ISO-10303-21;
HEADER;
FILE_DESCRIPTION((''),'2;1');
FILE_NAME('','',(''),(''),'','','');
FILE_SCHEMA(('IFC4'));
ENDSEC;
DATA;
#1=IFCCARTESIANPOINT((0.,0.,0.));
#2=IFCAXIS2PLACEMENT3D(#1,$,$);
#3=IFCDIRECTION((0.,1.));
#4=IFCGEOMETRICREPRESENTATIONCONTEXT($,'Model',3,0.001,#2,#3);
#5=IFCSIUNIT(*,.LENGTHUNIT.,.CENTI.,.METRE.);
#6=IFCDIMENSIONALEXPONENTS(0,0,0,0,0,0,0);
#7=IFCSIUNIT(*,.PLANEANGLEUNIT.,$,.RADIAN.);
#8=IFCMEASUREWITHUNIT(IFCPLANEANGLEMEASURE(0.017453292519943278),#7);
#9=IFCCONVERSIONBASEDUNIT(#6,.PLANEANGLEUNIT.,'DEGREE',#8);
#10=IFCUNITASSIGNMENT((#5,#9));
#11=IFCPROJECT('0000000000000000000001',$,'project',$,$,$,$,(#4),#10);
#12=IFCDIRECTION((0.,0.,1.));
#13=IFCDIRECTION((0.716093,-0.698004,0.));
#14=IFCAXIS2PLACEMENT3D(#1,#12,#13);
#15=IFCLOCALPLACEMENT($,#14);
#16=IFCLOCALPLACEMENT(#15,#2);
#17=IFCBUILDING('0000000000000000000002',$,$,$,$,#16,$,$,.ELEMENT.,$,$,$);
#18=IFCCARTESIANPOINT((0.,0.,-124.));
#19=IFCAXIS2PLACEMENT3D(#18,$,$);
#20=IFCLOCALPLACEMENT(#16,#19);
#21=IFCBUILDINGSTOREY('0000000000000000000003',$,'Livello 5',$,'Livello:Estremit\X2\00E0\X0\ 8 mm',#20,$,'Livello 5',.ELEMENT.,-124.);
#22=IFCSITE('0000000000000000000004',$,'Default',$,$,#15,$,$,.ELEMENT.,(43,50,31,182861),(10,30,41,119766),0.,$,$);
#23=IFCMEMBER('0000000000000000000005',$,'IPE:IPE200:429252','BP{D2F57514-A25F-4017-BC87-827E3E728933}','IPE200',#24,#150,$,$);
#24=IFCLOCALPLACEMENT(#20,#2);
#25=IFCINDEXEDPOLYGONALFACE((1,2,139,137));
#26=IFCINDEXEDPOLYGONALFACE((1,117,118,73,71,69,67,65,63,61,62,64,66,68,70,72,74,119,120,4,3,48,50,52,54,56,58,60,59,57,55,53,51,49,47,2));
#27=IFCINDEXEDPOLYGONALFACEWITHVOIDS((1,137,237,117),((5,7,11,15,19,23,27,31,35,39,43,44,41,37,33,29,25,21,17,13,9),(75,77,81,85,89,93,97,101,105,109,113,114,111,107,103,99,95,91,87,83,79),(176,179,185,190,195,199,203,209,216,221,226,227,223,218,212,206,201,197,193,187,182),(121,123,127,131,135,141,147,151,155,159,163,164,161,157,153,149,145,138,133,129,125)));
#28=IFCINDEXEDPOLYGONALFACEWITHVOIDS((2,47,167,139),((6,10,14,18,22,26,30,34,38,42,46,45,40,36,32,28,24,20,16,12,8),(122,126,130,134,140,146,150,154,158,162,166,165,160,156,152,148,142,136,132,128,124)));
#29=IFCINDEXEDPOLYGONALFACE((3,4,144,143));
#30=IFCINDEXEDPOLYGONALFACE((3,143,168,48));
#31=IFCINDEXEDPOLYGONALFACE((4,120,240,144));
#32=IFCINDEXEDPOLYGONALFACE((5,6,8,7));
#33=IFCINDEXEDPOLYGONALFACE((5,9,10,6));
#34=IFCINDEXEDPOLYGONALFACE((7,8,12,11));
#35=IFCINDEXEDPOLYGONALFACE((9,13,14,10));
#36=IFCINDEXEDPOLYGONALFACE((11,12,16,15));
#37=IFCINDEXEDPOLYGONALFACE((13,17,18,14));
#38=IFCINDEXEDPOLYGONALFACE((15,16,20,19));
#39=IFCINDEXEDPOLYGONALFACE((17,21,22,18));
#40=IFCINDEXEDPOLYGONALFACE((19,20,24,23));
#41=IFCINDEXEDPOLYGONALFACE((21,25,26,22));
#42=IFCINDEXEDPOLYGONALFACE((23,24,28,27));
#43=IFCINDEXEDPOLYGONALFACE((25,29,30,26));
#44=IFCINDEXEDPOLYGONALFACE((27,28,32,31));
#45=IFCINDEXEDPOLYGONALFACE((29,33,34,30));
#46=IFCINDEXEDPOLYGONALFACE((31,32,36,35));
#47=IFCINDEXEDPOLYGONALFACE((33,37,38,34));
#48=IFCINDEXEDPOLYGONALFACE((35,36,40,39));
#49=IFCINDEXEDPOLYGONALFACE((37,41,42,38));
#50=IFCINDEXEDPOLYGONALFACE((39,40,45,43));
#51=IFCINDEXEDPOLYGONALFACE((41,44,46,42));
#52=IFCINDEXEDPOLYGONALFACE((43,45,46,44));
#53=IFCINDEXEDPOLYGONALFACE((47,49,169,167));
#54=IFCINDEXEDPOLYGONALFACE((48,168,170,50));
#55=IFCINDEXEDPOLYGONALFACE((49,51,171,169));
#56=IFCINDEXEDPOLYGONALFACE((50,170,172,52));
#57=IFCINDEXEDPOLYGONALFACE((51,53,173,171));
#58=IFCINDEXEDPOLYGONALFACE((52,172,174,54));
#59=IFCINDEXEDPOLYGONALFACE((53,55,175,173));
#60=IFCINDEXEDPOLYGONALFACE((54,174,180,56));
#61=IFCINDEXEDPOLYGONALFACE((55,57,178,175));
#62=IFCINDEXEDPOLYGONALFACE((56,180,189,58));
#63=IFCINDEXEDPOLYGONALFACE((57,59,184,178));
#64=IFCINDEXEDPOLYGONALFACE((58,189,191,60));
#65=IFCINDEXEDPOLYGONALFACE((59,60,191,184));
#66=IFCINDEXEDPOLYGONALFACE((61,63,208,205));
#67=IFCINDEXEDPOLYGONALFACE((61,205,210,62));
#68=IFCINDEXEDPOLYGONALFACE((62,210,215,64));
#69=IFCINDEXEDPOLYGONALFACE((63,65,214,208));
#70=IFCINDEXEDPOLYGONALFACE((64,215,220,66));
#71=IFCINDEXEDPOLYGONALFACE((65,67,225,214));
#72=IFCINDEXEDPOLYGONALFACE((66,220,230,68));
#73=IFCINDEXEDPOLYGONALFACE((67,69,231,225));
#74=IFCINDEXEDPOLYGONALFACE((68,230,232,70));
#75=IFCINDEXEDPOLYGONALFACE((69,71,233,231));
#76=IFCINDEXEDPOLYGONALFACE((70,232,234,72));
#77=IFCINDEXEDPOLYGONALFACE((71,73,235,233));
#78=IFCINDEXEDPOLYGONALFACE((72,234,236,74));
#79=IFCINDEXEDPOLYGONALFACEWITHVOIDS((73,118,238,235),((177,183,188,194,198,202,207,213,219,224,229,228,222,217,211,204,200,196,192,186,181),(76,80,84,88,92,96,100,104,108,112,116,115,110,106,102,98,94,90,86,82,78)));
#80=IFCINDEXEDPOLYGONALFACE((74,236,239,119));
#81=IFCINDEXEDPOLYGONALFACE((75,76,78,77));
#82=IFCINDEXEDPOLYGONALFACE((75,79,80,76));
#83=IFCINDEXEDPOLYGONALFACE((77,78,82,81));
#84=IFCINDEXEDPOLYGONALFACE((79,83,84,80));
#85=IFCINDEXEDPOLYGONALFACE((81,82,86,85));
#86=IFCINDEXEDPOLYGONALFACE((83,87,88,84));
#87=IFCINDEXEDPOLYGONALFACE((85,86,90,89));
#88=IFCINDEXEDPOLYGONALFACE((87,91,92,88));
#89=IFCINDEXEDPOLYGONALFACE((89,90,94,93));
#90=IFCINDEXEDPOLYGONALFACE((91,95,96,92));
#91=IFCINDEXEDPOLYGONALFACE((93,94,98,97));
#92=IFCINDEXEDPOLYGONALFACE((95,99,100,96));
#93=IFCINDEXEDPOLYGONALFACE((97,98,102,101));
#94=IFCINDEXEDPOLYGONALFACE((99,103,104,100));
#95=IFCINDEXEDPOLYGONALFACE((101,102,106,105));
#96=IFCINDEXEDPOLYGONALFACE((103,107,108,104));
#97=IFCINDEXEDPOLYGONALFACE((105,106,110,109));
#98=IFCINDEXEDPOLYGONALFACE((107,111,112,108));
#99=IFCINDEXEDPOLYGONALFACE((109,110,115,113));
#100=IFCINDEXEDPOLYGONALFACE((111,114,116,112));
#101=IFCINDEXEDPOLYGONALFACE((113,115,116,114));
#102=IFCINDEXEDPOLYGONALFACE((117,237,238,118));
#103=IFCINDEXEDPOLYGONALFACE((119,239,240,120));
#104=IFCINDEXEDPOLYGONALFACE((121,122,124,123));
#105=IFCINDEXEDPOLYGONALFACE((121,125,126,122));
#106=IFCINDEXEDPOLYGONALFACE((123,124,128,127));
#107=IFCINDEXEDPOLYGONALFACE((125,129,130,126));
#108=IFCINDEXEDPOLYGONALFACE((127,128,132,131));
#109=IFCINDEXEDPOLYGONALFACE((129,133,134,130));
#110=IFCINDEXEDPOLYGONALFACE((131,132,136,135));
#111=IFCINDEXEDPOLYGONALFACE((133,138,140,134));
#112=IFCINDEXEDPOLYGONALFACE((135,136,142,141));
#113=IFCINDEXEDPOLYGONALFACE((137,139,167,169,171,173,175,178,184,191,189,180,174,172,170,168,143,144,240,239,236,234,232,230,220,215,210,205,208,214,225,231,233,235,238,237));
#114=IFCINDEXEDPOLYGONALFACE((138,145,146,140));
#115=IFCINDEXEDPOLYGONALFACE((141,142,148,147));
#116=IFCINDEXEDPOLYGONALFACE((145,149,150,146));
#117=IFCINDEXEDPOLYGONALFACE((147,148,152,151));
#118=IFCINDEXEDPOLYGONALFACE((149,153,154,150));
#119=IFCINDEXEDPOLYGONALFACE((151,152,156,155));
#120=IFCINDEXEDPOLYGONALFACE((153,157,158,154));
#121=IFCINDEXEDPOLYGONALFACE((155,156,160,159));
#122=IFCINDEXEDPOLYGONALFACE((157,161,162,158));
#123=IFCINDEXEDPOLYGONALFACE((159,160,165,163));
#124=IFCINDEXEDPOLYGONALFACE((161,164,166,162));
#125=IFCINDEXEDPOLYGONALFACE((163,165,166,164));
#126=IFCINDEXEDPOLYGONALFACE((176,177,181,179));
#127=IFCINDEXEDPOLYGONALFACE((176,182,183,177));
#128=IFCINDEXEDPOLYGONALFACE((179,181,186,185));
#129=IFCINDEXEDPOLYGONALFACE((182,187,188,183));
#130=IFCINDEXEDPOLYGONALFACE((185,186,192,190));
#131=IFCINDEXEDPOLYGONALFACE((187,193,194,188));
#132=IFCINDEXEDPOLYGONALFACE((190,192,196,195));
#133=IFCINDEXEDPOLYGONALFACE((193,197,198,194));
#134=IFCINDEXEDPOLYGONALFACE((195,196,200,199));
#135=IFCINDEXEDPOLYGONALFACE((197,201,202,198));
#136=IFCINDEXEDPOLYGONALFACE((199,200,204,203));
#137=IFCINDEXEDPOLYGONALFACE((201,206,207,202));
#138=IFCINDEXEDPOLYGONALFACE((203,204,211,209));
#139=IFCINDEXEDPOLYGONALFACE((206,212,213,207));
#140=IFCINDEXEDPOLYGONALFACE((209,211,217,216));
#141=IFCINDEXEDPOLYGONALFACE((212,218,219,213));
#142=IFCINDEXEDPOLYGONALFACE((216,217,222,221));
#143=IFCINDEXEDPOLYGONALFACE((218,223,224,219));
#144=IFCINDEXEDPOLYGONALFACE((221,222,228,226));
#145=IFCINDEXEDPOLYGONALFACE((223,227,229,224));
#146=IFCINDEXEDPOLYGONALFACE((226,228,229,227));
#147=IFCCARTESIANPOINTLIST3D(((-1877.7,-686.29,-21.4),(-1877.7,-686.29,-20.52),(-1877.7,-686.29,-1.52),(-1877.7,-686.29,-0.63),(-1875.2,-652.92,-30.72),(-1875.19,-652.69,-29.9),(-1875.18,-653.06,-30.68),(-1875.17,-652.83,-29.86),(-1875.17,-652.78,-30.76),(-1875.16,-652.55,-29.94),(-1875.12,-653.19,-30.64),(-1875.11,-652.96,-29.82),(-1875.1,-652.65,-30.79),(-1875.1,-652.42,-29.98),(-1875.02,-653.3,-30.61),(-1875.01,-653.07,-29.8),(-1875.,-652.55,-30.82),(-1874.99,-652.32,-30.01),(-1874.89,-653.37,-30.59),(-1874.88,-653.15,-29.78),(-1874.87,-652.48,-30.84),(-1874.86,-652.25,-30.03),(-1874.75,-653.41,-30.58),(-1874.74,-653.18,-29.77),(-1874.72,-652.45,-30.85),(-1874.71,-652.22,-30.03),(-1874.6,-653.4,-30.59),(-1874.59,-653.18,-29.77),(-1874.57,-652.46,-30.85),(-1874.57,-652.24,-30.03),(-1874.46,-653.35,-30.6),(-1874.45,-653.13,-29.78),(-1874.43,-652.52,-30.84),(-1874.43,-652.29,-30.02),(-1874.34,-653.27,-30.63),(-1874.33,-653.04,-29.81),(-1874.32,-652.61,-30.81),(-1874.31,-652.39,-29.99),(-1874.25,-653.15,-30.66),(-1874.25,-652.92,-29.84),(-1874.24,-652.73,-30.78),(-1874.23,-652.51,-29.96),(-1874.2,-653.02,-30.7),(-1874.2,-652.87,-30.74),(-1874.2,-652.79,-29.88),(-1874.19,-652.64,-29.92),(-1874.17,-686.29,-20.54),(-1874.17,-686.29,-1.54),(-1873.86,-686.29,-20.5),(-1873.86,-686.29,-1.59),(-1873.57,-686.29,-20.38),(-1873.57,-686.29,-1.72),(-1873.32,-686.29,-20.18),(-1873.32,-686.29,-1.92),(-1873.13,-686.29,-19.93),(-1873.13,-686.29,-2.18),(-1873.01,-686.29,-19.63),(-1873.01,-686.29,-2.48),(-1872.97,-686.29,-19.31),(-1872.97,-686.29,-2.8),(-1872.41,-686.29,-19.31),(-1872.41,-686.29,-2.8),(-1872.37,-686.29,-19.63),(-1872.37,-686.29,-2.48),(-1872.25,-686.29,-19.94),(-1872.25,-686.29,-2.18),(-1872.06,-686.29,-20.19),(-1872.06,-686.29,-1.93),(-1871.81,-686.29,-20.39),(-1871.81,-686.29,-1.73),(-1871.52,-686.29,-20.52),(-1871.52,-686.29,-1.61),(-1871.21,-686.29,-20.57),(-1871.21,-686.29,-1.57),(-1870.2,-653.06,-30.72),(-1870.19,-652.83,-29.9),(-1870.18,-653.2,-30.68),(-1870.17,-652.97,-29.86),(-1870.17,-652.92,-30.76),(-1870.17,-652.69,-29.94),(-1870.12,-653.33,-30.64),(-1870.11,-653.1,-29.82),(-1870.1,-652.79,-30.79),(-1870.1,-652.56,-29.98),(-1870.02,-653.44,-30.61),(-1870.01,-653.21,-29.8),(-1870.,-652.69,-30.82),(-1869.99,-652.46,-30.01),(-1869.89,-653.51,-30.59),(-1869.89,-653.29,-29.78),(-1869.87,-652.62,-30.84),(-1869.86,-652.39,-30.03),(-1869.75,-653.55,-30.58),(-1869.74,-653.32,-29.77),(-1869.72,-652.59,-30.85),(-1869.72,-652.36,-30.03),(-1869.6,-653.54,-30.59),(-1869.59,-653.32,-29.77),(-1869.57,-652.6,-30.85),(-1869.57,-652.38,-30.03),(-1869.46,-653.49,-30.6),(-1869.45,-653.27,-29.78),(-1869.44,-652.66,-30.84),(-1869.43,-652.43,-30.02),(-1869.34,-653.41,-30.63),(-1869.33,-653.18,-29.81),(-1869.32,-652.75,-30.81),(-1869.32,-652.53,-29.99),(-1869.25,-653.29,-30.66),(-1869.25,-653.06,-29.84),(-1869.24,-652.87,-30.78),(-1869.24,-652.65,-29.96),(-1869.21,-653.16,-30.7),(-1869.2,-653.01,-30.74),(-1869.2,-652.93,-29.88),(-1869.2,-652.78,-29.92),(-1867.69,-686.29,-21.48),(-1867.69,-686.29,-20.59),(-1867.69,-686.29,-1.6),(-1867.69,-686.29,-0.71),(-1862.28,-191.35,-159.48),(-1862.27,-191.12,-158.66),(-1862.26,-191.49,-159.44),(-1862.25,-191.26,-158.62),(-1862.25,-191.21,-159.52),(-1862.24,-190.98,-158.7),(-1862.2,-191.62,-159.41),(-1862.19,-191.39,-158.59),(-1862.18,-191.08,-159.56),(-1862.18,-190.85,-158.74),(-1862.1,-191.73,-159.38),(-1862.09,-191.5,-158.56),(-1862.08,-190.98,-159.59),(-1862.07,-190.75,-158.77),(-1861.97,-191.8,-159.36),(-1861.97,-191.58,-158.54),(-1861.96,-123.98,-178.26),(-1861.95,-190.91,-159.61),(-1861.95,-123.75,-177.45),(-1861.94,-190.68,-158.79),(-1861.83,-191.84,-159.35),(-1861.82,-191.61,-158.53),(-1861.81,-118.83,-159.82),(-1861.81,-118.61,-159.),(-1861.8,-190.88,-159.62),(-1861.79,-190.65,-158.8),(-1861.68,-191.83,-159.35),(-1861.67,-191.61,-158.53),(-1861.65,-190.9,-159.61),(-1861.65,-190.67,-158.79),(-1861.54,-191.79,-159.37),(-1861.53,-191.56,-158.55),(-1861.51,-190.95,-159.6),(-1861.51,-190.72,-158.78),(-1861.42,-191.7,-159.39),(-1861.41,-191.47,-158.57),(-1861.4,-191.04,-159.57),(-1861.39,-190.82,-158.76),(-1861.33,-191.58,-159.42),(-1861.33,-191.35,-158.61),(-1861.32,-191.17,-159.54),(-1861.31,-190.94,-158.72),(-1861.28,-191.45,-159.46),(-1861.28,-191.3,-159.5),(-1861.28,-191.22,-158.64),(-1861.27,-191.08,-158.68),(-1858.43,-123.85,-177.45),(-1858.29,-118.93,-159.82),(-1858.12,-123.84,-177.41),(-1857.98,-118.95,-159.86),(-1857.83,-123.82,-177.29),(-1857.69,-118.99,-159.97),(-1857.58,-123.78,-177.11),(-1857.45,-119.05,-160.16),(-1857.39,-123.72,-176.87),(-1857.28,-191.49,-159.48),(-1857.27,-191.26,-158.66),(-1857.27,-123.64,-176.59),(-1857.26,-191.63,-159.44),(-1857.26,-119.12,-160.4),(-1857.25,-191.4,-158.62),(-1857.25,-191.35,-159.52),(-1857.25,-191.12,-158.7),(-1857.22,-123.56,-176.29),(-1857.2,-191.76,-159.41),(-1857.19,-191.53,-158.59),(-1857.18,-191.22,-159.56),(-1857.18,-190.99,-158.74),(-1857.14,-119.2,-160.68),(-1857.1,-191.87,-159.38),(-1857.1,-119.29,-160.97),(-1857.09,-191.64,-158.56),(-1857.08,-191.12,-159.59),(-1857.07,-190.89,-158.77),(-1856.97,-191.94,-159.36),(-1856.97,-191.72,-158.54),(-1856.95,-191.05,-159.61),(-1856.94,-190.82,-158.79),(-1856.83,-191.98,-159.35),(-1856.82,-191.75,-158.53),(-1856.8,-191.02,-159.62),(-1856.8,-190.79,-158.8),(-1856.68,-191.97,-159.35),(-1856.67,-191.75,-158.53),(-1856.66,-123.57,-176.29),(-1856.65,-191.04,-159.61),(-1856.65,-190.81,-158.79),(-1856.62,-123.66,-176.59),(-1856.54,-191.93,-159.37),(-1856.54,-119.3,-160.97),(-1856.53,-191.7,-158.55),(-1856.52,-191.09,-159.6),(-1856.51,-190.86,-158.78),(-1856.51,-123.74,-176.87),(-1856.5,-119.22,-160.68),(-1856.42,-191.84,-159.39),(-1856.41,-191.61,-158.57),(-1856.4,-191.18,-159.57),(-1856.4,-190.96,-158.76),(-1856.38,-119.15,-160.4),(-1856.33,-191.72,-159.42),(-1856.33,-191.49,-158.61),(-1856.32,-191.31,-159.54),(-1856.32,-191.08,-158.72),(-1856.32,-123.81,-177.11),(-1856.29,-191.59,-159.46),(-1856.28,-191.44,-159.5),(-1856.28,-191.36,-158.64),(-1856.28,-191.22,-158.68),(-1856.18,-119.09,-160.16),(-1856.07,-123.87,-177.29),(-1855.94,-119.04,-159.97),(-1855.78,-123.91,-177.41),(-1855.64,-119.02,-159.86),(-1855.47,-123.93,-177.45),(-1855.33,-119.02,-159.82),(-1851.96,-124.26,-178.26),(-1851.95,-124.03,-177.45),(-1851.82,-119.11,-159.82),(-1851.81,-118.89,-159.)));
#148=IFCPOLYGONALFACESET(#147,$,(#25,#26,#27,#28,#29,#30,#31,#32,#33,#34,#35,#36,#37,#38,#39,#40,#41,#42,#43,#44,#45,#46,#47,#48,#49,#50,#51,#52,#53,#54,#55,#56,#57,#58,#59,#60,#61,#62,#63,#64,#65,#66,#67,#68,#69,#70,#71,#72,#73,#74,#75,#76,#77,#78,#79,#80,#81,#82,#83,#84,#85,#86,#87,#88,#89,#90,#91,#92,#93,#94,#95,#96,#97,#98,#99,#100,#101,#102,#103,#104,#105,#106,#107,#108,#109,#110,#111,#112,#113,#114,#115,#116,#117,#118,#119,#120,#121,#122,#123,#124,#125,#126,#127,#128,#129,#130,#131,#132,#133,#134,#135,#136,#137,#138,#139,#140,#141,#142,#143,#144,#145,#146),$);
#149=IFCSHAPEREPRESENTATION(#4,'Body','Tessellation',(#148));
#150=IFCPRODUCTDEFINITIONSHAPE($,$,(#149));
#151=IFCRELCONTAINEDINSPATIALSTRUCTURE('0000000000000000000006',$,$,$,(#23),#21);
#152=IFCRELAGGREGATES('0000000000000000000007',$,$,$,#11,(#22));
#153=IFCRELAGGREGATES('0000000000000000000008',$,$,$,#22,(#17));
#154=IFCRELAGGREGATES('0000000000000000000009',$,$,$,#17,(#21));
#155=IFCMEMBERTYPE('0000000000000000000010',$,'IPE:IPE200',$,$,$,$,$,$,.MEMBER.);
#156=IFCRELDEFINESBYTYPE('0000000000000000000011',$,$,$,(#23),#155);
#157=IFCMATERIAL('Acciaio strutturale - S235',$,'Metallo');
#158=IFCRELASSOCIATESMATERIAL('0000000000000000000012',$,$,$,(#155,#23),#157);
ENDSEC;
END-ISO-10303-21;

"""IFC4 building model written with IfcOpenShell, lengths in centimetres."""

from ifc_helpers import new_model, entity, si_unit, converted_unit, direction, frame, frame_2d, origin, origin_2d, place, context, project, spatial, circle, i_section, extrude, clip, halfspace, material, type_object, element, save


model = new_model("IFC4")

# Units and contexts
model_context = context("Model", 3, precision=0.001, world=origin(), true_north=direction((0.0, 1.0)))
ifc_project = project(units=[si_unit("LENGTHUNIT", "METRE", prefix="CENTI"), converted_unit("PLANEANGLEUNIT", "DEGREE", entity("IfcPlaneAngleMeasure", 0.017453292519943278), si_unit("PLANEANGLEUNIT", "RADIAN"), dimensions=[0, 0, 0, 0, 0, 0, 0])], contexts=[model_context])

# Site, building, storey
site_placement = place(None, frame((0.0, 0.0, 0.0), z_axis=(0.0, 0.0, 1.0), x_axis=(0.716093, -0.698004, 0.0)))
site = spatial("IfcSite", under=ifc_project, at=site_placement, Name="Default", CompositionType="ELEMENT", RefLatitude=(43, 50, 31, 182861), RefLongitude=(10, 30, 41, 119766), RefElevation=0.0)
building_placement = place(site_placement, origin())
building = spatial("IfcBuilding", under=site, at=building_placement, CompositionType="ELEMENT")
storey_placement = place(building_placement, frame((0.0, 0.0, -124.0)))
storey = spatial("IfcBuildingStorey", under=building, at=storey_placement, Name="Livello 5", ObjectType="Livello:Estremità 8 mm", LongName="Livello 5", CompositionType="ELEMENT", Elevation=-124.0)

# Shared definitions
ifc_material_1 = material(Name="Acciaio strutturale - S235", Category="Metallo")

# Member, openings
member_type_1 = type_object("IfcMemberType", Name="IPE:IPE200", PredefinedType="MEMBER", material=ifc_material_1)
member_1_placement = place(storey_placement, frame((-1873.81, -726.15, 0.07), z_axis=(-0.026952, -0.962871, 0.268612), x_axis=(0.999608, -0.02798, 0.0)))
member_1 = element("IfcMember", 1, at=member_1_placement, inside=storey, type_object=member_type_1, material=ifc_material_1, Name="IPE:IPE200:429252", Description="BP{D2F57514-A25F-4017-BC87-827E3E728933}", ObjectType="IPE200", context=model_context, shape_type="Clipping", body=[
    clip(extrude(i_section(OverallWidth=10.0, OverallDepth=20.0, WebThickness=0.56, FlangeThickness=0.85, FilletRadius=1.2, at=origin_2d()), origin(), (0.0, 0.0, -1.0), 628.04), halfspace(frame((1871.96, 144.17, -55.6), z_axis=(-0.02798, 0.268507, -0.962871), x_axis=(-0.999608, -0.007516, 0.026952)), True)),
])
opening_1_placement = place(member_1_placement, frame((1.56, -9.1, -558.11), z_axis=(0.0, 1.0, 0.0), x_axis=(-1.0, 0.0, 0.0)))
element("IfcOpeningElement", 2, at=opening_1_placement, cuts=member_1, ObjectType="Opening", context=model_context, shape_type="SweptSolid", body=[
    extrude(circle(Radius=0.5, at=frame_2d((-0.5, 0.0), x_axis=(1.0, 0.0))), origin(), (0.0, 0.0, -1.0), 0.95),
])
opening_2_placement = place(member_1_placement, frame((-3.44, -9.1, -558.11), z_axis=(0.0, 1.0, 0.0), x_axis=(-1.0, 0.0, 0.0)))
element("IfcOpeningElement", 3, at=opening_2_placement, cuts=member_1, ObjectType="Opening", context=model_context, shape_type="SweptSolid", body=[
    extrude(circle(Radius=0.5, at=frame_2d((-0.5, 0.0), x_axis=(1.0, 0.0))), origin(), (0.0, 0.0, -1.0), 0.95),
])
opening_3_placement = place(member_1_placement, frame((1.56, -9.1, -78.75), z_axis=(0.0, 1.0, 0.0), x_axis=(-1.0, 0.0, 0.0)))
element("IfcOpeningElement", 4, at=opening_3_placement, cuts=member_1, ObjectType="Opening", context=model_context, shape_type="SweptSolid", body=[
    extrude(circle(Radius=0.5, at=frame_2d((-0.5, 0.0), x_axis=(1.0, 0.0))), origin(), (0.0, 0.0, -1.0), 0.95),
])
opening_4_placement = place(member_1_placement, frame((-3.44, -9.1, -78.75), z_axis=(0.0, 1.0, 0.0), x_axis=(-1.0, 0.0, 0.0)))
element("IfcOpeningElement", 5, at=opening_4_placement, cuts=member_1, ObjectType="Opening", context=model_context, shape_type="SweptSolid", body=[
    extrude(circle(Radius=0.5, at=frame_2d((-0.5, 0.0), x_axis=(1.0, 0.0))), origin(), (0.0, 0.0, -1.0), 0.95),
])

save(model, "model.ifc")
